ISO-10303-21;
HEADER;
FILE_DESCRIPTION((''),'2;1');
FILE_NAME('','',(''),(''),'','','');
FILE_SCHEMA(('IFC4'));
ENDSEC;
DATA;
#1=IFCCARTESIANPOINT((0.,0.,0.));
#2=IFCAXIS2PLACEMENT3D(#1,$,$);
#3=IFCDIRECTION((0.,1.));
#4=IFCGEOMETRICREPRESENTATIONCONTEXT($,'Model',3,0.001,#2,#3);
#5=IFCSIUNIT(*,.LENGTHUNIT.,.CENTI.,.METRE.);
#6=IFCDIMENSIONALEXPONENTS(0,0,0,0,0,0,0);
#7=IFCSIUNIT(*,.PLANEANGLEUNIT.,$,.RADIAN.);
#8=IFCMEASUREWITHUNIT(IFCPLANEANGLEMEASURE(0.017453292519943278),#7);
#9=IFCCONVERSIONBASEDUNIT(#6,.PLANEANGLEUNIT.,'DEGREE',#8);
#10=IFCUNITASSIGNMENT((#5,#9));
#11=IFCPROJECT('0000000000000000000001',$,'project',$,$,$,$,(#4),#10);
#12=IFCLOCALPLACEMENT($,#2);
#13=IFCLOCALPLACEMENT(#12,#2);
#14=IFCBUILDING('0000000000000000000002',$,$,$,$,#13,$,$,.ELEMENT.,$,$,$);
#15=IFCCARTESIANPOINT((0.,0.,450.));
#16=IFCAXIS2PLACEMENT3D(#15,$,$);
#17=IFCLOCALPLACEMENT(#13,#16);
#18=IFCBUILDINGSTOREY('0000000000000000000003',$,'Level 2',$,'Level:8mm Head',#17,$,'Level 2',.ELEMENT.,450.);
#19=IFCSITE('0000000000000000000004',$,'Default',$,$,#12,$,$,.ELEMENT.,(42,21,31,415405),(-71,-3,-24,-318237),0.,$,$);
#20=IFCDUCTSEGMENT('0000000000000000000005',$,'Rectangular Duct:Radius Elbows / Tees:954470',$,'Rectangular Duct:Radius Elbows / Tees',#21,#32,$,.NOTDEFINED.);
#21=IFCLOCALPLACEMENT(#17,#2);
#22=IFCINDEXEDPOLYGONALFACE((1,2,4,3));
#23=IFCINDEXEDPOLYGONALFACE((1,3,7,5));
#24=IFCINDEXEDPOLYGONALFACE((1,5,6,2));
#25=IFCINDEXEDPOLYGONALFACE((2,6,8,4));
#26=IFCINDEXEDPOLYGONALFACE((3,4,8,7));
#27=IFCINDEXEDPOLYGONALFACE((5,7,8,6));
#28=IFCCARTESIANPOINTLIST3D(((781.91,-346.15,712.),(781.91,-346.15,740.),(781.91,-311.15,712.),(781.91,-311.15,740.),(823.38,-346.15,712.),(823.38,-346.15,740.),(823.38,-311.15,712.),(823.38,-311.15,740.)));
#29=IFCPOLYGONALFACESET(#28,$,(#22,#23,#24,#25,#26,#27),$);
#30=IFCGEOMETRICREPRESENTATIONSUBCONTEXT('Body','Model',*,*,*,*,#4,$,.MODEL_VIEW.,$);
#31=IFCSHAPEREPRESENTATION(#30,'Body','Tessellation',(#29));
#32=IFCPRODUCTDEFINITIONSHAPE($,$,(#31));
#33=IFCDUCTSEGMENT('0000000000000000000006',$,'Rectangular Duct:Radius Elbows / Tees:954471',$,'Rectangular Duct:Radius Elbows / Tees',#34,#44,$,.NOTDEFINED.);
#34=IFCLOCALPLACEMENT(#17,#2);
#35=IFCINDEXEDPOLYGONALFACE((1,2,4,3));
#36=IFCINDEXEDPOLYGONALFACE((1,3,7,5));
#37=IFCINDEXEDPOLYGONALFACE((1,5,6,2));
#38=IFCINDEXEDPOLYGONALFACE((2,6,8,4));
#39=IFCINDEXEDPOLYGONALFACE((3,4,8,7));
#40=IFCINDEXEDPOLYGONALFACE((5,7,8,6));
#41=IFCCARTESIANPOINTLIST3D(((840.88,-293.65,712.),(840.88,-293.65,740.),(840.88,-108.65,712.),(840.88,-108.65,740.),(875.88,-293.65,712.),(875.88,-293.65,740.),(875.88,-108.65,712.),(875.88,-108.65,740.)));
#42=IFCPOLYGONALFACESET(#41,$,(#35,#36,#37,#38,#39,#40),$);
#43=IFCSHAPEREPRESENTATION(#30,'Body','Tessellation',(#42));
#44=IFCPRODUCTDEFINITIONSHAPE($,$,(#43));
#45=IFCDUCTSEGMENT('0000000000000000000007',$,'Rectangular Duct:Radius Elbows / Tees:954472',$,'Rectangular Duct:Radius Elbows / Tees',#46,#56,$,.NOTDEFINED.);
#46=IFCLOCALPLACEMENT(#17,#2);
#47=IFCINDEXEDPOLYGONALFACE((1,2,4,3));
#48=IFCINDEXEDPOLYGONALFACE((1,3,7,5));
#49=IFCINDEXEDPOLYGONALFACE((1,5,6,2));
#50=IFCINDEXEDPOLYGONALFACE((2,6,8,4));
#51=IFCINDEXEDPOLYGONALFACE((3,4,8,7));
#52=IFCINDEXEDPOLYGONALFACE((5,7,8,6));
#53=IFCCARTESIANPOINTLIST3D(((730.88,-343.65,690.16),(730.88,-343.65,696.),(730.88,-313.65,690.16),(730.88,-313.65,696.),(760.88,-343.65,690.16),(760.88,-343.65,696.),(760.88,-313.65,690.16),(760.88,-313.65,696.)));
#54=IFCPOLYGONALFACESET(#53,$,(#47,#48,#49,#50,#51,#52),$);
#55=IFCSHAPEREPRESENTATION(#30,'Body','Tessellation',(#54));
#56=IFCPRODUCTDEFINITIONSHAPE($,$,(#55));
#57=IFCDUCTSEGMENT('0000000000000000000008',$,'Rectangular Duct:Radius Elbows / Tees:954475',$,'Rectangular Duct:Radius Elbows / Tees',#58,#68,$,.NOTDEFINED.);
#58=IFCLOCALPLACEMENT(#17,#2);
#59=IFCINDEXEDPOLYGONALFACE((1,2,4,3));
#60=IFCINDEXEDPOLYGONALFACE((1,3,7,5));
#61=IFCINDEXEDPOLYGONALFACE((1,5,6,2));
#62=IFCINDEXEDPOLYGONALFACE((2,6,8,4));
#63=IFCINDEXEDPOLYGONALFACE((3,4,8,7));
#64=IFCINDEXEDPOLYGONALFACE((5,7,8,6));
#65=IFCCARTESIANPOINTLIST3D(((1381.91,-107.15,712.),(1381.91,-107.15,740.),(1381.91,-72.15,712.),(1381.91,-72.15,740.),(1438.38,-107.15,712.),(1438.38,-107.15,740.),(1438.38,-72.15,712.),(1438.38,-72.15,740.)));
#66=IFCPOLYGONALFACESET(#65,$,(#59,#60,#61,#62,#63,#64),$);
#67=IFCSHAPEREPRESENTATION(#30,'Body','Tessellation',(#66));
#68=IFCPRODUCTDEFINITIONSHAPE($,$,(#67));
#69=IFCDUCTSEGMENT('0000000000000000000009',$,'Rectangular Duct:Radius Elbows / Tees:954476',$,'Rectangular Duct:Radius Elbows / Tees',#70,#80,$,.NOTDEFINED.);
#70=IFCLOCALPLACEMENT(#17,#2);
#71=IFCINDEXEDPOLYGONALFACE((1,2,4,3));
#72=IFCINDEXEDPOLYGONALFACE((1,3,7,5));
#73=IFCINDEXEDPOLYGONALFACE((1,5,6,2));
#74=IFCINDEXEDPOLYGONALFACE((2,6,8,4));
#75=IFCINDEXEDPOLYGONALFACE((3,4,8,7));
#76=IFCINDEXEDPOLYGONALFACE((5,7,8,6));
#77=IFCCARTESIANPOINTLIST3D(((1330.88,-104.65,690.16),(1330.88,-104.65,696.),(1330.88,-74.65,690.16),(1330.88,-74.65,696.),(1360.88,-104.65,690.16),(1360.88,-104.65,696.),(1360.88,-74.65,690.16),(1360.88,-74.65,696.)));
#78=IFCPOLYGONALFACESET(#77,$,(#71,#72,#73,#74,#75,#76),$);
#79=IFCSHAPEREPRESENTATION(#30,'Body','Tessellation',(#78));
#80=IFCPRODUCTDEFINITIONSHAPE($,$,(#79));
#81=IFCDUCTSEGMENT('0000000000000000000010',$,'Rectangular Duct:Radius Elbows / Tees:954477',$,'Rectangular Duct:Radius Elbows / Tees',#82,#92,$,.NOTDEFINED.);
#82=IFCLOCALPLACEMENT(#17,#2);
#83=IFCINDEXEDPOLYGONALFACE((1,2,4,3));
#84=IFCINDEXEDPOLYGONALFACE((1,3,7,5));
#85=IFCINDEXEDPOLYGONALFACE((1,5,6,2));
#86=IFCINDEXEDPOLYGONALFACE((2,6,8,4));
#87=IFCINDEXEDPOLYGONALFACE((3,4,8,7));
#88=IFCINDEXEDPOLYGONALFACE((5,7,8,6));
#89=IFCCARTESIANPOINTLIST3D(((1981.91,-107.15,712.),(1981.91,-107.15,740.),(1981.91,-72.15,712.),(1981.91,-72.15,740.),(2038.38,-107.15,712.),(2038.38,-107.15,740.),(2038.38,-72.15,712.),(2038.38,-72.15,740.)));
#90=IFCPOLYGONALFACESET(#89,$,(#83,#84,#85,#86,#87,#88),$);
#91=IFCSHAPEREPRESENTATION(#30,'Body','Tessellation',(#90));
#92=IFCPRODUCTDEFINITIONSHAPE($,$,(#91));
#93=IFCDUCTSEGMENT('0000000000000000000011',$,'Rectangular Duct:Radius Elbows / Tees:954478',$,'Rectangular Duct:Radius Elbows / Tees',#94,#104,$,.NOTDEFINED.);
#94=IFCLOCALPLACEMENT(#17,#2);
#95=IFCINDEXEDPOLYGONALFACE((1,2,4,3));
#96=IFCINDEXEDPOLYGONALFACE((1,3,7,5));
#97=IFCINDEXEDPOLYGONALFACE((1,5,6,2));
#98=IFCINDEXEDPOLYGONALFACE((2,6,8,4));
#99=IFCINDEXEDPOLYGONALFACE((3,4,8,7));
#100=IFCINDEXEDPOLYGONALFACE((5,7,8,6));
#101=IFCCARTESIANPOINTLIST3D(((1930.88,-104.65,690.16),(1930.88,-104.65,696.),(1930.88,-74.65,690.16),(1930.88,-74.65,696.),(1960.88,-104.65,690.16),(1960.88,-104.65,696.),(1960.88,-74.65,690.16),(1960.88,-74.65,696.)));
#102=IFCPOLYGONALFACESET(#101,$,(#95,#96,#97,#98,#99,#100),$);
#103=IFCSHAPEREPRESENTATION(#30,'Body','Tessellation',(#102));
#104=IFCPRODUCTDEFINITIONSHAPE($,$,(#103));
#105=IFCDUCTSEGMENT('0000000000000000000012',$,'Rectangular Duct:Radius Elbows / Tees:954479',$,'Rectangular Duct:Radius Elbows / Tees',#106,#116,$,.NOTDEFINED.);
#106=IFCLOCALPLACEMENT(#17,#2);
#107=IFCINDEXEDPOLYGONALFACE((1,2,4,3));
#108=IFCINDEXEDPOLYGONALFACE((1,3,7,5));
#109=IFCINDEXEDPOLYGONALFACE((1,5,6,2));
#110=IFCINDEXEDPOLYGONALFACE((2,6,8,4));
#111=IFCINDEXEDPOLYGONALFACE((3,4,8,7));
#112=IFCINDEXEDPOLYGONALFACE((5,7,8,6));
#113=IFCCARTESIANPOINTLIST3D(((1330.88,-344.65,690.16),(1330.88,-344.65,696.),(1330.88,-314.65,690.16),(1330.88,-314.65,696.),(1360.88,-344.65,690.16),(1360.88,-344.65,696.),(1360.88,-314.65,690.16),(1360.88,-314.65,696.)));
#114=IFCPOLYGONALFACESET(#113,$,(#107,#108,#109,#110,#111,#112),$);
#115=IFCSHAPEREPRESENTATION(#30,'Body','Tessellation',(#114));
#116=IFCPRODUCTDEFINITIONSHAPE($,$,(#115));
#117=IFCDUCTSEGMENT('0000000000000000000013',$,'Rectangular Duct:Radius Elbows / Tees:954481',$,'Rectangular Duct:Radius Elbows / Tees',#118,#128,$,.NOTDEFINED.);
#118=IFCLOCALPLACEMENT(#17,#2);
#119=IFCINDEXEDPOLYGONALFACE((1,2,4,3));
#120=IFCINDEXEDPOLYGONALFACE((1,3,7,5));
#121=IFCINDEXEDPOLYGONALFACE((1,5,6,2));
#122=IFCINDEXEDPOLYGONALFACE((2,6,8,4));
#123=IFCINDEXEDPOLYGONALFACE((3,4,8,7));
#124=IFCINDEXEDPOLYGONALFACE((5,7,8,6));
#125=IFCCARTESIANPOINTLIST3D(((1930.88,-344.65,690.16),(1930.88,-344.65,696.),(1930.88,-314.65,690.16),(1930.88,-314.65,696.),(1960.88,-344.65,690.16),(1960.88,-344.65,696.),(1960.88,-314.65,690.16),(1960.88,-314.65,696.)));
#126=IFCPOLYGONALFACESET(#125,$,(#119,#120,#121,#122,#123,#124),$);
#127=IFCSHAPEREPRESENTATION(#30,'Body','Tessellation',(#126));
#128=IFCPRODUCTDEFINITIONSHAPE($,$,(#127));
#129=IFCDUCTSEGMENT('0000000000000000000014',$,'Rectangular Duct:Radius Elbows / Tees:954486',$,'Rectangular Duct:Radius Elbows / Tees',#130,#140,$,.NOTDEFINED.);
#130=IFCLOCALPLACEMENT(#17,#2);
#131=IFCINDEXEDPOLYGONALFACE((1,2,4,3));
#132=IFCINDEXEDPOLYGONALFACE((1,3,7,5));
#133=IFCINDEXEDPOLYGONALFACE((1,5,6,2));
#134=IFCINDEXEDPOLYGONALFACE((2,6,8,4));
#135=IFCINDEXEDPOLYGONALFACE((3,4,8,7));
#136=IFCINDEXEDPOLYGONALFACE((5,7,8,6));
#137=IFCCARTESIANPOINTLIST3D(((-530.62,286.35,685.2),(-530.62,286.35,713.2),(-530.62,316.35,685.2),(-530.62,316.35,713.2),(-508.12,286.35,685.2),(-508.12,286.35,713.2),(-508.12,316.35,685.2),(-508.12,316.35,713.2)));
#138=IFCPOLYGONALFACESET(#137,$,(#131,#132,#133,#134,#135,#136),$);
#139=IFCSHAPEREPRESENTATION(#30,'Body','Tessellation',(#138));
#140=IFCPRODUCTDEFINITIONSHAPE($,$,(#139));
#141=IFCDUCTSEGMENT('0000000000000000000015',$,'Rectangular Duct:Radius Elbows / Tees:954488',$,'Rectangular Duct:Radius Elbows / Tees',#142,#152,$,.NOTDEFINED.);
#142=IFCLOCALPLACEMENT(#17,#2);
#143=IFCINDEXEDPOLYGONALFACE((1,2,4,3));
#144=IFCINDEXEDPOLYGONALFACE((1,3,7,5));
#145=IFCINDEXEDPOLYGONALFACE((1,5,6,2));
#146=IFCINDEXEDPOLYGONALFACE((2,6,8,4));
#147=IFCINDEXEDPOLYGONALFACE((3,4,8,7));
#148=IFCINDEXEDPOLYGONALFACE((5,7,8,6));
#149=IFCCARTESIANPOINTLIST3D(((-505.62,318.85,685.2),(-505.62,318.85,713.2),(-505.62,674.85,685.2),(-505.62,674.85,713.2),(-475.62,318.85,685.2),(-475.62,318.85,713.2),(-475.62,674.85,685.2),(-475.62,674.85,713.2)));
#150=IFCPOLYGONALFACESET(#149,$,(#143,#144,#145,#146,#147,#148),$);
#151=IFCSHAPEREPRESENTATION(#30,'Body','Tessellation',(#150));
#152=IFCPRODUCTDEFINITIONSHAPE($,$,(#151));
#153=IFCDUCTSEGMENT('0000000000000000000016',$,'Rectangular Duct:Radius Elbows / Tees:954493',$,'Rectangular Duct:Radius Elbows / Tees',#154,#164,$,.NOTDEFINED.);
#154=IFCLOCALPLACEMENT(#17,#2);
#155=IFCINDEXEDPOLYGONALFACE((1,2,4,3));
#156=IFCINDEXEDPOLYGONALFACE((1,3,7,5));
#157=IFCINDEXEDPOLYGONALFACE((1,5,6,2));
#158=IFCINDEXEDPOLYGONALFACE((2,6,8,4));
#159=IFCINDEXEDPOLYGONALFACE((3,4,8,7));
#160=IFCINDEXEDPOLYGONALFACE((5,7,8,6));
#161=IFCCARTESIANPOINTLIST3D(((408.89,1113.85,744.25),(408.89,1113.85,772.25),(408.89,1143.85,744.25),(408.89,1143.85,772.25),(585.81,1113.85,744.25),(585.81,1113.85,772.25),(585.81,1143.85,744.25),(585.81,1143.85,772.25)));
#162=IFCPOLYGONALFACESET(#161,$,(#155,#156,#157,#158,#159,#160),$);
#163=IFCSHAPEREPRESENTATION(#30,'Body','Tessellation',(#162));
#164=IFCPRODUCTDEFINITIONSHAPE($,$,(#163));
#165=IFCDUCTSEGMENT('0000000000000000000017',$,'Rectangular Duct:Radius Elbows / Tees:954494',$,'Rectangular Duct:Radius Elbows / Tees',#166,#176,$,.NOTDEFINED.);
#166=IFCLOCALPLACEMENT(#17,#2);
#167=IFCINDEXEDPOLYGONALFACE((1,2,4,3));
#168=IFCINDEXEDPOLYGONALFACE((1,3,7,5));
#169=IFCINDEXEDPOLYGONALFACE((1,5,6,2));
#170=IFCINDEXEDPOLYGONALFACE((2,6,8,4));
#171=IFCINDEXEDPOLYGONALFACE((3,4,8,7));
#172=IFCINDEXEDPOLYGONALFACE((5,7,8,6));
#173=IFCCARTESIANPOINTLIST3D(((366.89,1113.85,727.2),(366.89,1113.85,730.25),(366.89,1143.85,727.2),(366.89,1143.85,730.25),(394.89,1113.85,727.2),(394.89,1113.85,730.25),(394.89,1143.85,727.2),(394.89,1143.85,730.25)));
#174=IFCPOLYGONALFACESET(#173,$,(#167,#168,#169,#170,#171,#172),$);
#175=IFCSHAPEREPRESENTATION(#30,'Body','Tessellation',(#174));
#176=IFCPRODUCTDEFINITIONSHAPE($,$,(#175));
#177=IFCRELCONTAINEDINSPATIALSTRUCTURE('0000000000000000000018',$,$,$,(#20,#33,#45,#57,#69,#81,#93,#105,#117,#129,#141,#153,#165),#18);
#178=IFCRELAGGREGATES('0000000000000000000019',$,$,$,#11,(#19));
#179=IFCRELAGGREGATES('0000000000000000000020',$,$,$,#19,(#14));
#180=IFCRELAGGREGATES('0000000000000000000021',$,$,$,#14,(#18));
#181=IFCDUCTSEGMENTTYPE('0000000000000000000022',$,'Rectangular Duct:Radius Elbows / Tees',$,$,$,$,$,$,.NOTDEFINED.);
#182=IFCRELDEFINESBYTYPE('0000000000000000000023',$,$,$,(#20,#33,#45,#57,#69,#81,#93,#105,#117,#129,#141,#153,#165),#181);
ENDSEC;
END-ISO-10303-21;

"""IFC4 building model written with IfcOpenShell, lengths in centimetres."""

from ifc_helpers import new_model, entity, si_unit, converted_unit, direction, frame, origin, place, context, subcontext, project, spatial, indexed_curve, outline, extrude, type_object, element, save


model = new_model("IFC4")

# Units and contexts
model_context = context("Model", 3, precision=0.001, world=origin(), true_north=direction((0.0, 1.0)))
body_context = subcontext(model_context, "Body", "Model", "MODEL_VIEW")
ifc_project = project(units=[si_unit("LENGTHUNIT", "METRE", prefix="CENTI"), converted_unit("PLANEANGLEUNIT", "DEGREE", entity("IfcPlaneAngleMeasure", 0.017453292519943278), si_unit("PLANEANGLEUNIT", "RADIAN"), dimensions=[0, 0, 0, 0, 0, 0, 0])], contexts=[model_context])

# Site, building, storey
site_placement = place(None, origin())
site = spatial("IfcSite", under=ifc_project, at=site_placement, Name="Default", CompositionType="ELEMENT", RefLatitude=(42, 21, 31, 415405), RefLongitude=(-71, -3, -24, -318237), RefElevation=0.0)
building_placement = place(site_placement, origin())
building = spatial("IfcBuilding", under=site, at=building_placement, CompositionType="ELEMENT")
storey_placement = place(building_placement, frame((0.0, 0.0, 450.0)))
storey = spatial("IfcBuildingStorey", under=building, at=storey_placement, Name="Level 2", ObjectType="Level:8mm Head", LongName="Level 2", CompositionType="ELEMENT", Elevation=450.0)

# Duct segments
duct_segment_type = type_object("IfcDuctSegmentType", Name="Rectangular Duct:Radius Elbows / Tees", PredefinedType="NOTDEFINED")
duct_segment_1_placement = place(storey_placement, origin())
element("IfcDuctSegment", 1, at=duct_segment_1_placement, inside=storey, type_object=duct_segment_type, Name="Rectangular Duct:Radius Elbows / Tees:954470", ObjectType="Rectangular Duct:Radius Elbows / Tees", PredefinedType="NOTDEFINED", context=body_context, shape_type="SweptSolid", body=[
    extrude(outline(indexed_curve([(-20.73, -17.5), (20.73, -17.5), (20.73, 17.5), (-20.73, 17.5), (-20.73, -17.5)], self_intersect=False)), frame((802.64, -328.65, 712.0)), (0.0, 0.0, 1.0), 28.0),
])
duct_segment_2_placement = place(storey_placement, origin())
element("IfcDuctSegment", 2, at=duct_segment_2_placement, inside=storey, type_object=duct_segment_type, Name="Rectangular Duct:Radius Elbows / Tees:954471", ObjectType="Rectangular Duct:Radius Elbows / Tees", PredefinedType="NOTDEFINED", context=body_context, shape_type="SweptSolid", body=[
    extrude(outline(indexed_curve([(-92.5, -17.5), (92.5, -17.5), (92.5, 17.5), (-92.5, 17.5), (-92.5, -17.5)], self_intersect=False)), frame((858.38, -201.15, 712.0), z_axis=(0.0, 0.0, 1.0), x_axis=(0.0, -1.0, 0.0)), (0.0, 0.0, 1.0), 28.0),
])
duct_segment_3_placement = place(storey_placement, origin())
element("IfcDuctSegment", 3, at=duct_segment_3_placement, inside=storey, type_object=duct_segment_type, Name="Rectangular Duct:Radius Elbows / Tees:954472", ObjectType="Rectangular Duct:Radius Elbows / Tees", PredefinedType="NOTDEFINED", context=body_context, shape_type="SweptSolid", body=[
    extrude(outline(indexed_curve([(-15.0, -15.0), (15.0, -15.0), (15.0, 15.0), (-15.0, 15.0), (-15.0, -15.0)], self_intersect=False)), frame((745.88, -328.65, 690.16)), (0.0, 0.0, 1.0), 5.84),
])
duct_segment_4_placement = place(storey_placement, origin())
element("IfcDuctSegment", 4, at=duct_segment_4_placement, inside=storey, type_object=duct_segment_type, Name="Rectangular Duct:Radius Elbows / Tees:954475", ObjectType="Rectangular Duct:Radius Elbows / Tees", PredefinedType="NOTDEFINED", context=body_context, shape_type="SweptSolid", body=[
    extrude(outline(indexed_curve([(-28.23, -17.5), (28.23, -17.5), (28.23, 17.5), (-28.23, 17.5), (-28.23, -17.5)], self_intersect=False)), frame((1410.14, -89.65, 712.0)), (0.0, 0.0, 1.0), 28.0),
])
duct_segment_5_placement = place(storey_placement, origin())
element("IfcDuctSegment", 5, at=duct_segment_5_placement, inside=storey, type_object=duct_segment_type, Name="Rectangular Duct:Radius Elbows / Tees:954476", ObjectType="Rectangular Duct:Radius Elbows / Tees", PredefinedType="NOTDEFINED", context=body_context, shape_type="SweptSolid", body=[
    extrude(outline(indexed_curve([(-15.0, -15.0), (15.0, -15.0), (15.0, 15.0), (-15.0, 15.0), (-15.0, -15.0)], self_intersect=False)), frame((1345.88, -89.65, 690.16)), (0.0, 0.0, 1.0), 5.84),
])
duct_segment_6_placement = place(storey_placement, origin())
element("IfcDuctSegment", 6, at=duct_segment_6_placement, inside=storey, type_object=duct_segment_type, Name="Rectangular Duct:Radius Elbows / Tees:954477", ObjectType="Rectangular Duct:Radius Elbows / Tees", PredefinedType="NOTDEFINED", context=body_context, shape_type="SweptSolid", body=[
    extrude(outline(indexed_curve([(-28.23, -17.5), (28.23, -17.5), (28.23, 17.5), (-28.23, 17.5), (-28.23, -17.5)], self_intersect=False)), frame((2010.14, -89.65, 712.0)), (0.0, 0.0, 1.0), 28.0),
])
duct_segment_7_placement = place(storey_placement, origin())
element("IfcDuctSegment", 7, at=duct_segment_7_placement, inside=storey, type_object=duct_segment_type, Name="Rectangular Duct:Radius Elbows / Tees:954478", ObjectType="Rectangular Duct:Radius Elbows / Tees", PredefinedType="NOTDEFINED", context=body_context, shape_type="SweptSolid", body=[
    extrude(outline(indexed_curve([(-15.0, -15.0), (15.0, -15.0), (15.0, 15.0), (-15.0, 15.0), (-15.0, -15.0)], self_intersect=False)), frame((1945.88, -89.65, 690.16)), (0.0, 0.0, 1.0), 5.84),
])
duct_segment_8_placement = place(storey_placement, origin())
element("IfcDuctSegment", 8, at=duct_segment_8_placement, inside=storey, type_object=duct_segment_type, Name="Rectangular Duct:Radius Elbows / Tees:954479", ObjectType="Rectangular Duct:Radius Elbows / Tees", PredefinedType="NOTDEFINED", context=body_context, shape_type="SweptSolid", body=[
    extrude(outline(indexed_curve([(-15.0, -15.0), (15.0, -15.0), (15.0, 15.0), (-15.0, 15.0), (-15.0, -15.0)], self_intersect=False)), frame((1345.88, -329.65, 690.16)), (0.0, 0.0, 1.0), 5.84),
])
duct_segment_9_placement = place(storey_placement, origin())
element("IfcDuctSegment", 9, at=duct_segment_9_placement, inside=storey, type_object=duct_segment_type, Name="Rectangular Duct:Radius Elbows / Tees:954481", ObjectType="Rectangular Duct:Radius Elbows / Tees", PredefinedType="NOTDEFINED", context=body_context, shape_type="SweptSolid", body=[
    extrude(outline(indexed_curve([(-15.0, -15.0), (15.0, -15.0), (15.0, 15.0), (-15.0, 15.0), (-15.0, -15.0)], self_intersect=False)), frame((1945.88, -329.65, 690.16)), (0.0, 0.0, 1.0), 5.84),
])
duct_segment_10_placement = place(storey_placement, origin())
element("IfcDuctSegment", 10, at=duct_segment_10_placement, inside=storey, type_object=duct_segment_type, Name="Rectangular Duct:Radius Elbows / Tees:954486", ObjectType="Rectangular Duct:Radius Elbows / Tees", PredefinedType="NOTDEFINED", context=body_context, shape_type="SweptSolid", body=[
    extrude(outline(indexed_curve([(-11.25, -15.0), (11.25, -15.0), (11.25, 15.0), (-11.25, 15.0), (-11.25, -15.0)], self_intersect=False)), frame((-519.37, 301.35, 685.2), z_axis=(0.0, 0.0, 1.0), x_axis=(-1.0, 0.0, 0.0)), (0.0, 0.0, 1.0), 28.0),
])
duct_segment_11_placement = place(storey_placement, origin())
element("IfcDuctSegment", 11, at=duct_segment_11_placement, inside=storey, type_object=duct_segment_type, Name="Rectangular Duct:Radius Elbows / Tees:954488", ObjectType="Rectangular Duct:Radius Elbows / Tees", PredefinedType="NOTDEFINED", context=body_context, shape_type="SweptSolid", body=[
    extrude(outline(indexed_curve([(-178.0, -15.0), (178.0, -15.0), (178.0, 15.0), (-178.0, 15.0), (-178.0, -15.0)], self_intersect=False)), frame((-490.62, 496.85, 685.2), z_axis=(0.0, 0.0, 1.0), x_axis=(0.0, -1.0, 0.0)), (0.0, 0.0, 1.0), 28.0),
])
duct_segment_12_placement = place(storey_placement, origin())
element("IfcDuctSegment", 12, at=duct_segment_12_placement, inside=storey, type_object=duct_segment_type, Name="Rectangular Duct:Radius Elbows / Tees:954493", ObjectType="Rectangular Duct:Radius Elbows / Tees", PredefinedType="NOTDEFINED", context=body_context, shape_type="SweptSolid", body=[
    extrude(outline(indexed_curve([(-88.46, -15.0), (88.46, -15.0), (88.46, 15.0), (-88.46, 15.0), (-88.46, -15.0)], self_intersect=False)), frame((497.35, 1128.85, 744.25)), (0.0, 0.0, 1.0), 28.0),
])
duct_segment_13_placement = place(storey_placement, origin())
element("IfcDuctSegment", 13, at=duct_segment_13_placement, inside=storey, type_object=duct_segment_type, Name="Rectangular Duct:Radius Elbows / Tees:954494", ObjectType="Rectangular Duct:Radius Elbows / Tees", PredefinedType="NOTDEFINED", context=body_context, shape_type="SweptSolid", body=[
    extrude(outline(indexed_curve([(-15.0, -14.0), (15.0, -14.0), (15.0, 14.0), (-15.0, 14.0), (-15.0, -14.0)], self_intersect=False)), frame((380.89, 1128.85, 727.2), z_axis=(0.0, 0.0, 1.0), x_axis=(0.0, 1.0, 0.0)), (0.0, 0.0, 1.0), 3.05),
])

save(model, "model.ifc")
